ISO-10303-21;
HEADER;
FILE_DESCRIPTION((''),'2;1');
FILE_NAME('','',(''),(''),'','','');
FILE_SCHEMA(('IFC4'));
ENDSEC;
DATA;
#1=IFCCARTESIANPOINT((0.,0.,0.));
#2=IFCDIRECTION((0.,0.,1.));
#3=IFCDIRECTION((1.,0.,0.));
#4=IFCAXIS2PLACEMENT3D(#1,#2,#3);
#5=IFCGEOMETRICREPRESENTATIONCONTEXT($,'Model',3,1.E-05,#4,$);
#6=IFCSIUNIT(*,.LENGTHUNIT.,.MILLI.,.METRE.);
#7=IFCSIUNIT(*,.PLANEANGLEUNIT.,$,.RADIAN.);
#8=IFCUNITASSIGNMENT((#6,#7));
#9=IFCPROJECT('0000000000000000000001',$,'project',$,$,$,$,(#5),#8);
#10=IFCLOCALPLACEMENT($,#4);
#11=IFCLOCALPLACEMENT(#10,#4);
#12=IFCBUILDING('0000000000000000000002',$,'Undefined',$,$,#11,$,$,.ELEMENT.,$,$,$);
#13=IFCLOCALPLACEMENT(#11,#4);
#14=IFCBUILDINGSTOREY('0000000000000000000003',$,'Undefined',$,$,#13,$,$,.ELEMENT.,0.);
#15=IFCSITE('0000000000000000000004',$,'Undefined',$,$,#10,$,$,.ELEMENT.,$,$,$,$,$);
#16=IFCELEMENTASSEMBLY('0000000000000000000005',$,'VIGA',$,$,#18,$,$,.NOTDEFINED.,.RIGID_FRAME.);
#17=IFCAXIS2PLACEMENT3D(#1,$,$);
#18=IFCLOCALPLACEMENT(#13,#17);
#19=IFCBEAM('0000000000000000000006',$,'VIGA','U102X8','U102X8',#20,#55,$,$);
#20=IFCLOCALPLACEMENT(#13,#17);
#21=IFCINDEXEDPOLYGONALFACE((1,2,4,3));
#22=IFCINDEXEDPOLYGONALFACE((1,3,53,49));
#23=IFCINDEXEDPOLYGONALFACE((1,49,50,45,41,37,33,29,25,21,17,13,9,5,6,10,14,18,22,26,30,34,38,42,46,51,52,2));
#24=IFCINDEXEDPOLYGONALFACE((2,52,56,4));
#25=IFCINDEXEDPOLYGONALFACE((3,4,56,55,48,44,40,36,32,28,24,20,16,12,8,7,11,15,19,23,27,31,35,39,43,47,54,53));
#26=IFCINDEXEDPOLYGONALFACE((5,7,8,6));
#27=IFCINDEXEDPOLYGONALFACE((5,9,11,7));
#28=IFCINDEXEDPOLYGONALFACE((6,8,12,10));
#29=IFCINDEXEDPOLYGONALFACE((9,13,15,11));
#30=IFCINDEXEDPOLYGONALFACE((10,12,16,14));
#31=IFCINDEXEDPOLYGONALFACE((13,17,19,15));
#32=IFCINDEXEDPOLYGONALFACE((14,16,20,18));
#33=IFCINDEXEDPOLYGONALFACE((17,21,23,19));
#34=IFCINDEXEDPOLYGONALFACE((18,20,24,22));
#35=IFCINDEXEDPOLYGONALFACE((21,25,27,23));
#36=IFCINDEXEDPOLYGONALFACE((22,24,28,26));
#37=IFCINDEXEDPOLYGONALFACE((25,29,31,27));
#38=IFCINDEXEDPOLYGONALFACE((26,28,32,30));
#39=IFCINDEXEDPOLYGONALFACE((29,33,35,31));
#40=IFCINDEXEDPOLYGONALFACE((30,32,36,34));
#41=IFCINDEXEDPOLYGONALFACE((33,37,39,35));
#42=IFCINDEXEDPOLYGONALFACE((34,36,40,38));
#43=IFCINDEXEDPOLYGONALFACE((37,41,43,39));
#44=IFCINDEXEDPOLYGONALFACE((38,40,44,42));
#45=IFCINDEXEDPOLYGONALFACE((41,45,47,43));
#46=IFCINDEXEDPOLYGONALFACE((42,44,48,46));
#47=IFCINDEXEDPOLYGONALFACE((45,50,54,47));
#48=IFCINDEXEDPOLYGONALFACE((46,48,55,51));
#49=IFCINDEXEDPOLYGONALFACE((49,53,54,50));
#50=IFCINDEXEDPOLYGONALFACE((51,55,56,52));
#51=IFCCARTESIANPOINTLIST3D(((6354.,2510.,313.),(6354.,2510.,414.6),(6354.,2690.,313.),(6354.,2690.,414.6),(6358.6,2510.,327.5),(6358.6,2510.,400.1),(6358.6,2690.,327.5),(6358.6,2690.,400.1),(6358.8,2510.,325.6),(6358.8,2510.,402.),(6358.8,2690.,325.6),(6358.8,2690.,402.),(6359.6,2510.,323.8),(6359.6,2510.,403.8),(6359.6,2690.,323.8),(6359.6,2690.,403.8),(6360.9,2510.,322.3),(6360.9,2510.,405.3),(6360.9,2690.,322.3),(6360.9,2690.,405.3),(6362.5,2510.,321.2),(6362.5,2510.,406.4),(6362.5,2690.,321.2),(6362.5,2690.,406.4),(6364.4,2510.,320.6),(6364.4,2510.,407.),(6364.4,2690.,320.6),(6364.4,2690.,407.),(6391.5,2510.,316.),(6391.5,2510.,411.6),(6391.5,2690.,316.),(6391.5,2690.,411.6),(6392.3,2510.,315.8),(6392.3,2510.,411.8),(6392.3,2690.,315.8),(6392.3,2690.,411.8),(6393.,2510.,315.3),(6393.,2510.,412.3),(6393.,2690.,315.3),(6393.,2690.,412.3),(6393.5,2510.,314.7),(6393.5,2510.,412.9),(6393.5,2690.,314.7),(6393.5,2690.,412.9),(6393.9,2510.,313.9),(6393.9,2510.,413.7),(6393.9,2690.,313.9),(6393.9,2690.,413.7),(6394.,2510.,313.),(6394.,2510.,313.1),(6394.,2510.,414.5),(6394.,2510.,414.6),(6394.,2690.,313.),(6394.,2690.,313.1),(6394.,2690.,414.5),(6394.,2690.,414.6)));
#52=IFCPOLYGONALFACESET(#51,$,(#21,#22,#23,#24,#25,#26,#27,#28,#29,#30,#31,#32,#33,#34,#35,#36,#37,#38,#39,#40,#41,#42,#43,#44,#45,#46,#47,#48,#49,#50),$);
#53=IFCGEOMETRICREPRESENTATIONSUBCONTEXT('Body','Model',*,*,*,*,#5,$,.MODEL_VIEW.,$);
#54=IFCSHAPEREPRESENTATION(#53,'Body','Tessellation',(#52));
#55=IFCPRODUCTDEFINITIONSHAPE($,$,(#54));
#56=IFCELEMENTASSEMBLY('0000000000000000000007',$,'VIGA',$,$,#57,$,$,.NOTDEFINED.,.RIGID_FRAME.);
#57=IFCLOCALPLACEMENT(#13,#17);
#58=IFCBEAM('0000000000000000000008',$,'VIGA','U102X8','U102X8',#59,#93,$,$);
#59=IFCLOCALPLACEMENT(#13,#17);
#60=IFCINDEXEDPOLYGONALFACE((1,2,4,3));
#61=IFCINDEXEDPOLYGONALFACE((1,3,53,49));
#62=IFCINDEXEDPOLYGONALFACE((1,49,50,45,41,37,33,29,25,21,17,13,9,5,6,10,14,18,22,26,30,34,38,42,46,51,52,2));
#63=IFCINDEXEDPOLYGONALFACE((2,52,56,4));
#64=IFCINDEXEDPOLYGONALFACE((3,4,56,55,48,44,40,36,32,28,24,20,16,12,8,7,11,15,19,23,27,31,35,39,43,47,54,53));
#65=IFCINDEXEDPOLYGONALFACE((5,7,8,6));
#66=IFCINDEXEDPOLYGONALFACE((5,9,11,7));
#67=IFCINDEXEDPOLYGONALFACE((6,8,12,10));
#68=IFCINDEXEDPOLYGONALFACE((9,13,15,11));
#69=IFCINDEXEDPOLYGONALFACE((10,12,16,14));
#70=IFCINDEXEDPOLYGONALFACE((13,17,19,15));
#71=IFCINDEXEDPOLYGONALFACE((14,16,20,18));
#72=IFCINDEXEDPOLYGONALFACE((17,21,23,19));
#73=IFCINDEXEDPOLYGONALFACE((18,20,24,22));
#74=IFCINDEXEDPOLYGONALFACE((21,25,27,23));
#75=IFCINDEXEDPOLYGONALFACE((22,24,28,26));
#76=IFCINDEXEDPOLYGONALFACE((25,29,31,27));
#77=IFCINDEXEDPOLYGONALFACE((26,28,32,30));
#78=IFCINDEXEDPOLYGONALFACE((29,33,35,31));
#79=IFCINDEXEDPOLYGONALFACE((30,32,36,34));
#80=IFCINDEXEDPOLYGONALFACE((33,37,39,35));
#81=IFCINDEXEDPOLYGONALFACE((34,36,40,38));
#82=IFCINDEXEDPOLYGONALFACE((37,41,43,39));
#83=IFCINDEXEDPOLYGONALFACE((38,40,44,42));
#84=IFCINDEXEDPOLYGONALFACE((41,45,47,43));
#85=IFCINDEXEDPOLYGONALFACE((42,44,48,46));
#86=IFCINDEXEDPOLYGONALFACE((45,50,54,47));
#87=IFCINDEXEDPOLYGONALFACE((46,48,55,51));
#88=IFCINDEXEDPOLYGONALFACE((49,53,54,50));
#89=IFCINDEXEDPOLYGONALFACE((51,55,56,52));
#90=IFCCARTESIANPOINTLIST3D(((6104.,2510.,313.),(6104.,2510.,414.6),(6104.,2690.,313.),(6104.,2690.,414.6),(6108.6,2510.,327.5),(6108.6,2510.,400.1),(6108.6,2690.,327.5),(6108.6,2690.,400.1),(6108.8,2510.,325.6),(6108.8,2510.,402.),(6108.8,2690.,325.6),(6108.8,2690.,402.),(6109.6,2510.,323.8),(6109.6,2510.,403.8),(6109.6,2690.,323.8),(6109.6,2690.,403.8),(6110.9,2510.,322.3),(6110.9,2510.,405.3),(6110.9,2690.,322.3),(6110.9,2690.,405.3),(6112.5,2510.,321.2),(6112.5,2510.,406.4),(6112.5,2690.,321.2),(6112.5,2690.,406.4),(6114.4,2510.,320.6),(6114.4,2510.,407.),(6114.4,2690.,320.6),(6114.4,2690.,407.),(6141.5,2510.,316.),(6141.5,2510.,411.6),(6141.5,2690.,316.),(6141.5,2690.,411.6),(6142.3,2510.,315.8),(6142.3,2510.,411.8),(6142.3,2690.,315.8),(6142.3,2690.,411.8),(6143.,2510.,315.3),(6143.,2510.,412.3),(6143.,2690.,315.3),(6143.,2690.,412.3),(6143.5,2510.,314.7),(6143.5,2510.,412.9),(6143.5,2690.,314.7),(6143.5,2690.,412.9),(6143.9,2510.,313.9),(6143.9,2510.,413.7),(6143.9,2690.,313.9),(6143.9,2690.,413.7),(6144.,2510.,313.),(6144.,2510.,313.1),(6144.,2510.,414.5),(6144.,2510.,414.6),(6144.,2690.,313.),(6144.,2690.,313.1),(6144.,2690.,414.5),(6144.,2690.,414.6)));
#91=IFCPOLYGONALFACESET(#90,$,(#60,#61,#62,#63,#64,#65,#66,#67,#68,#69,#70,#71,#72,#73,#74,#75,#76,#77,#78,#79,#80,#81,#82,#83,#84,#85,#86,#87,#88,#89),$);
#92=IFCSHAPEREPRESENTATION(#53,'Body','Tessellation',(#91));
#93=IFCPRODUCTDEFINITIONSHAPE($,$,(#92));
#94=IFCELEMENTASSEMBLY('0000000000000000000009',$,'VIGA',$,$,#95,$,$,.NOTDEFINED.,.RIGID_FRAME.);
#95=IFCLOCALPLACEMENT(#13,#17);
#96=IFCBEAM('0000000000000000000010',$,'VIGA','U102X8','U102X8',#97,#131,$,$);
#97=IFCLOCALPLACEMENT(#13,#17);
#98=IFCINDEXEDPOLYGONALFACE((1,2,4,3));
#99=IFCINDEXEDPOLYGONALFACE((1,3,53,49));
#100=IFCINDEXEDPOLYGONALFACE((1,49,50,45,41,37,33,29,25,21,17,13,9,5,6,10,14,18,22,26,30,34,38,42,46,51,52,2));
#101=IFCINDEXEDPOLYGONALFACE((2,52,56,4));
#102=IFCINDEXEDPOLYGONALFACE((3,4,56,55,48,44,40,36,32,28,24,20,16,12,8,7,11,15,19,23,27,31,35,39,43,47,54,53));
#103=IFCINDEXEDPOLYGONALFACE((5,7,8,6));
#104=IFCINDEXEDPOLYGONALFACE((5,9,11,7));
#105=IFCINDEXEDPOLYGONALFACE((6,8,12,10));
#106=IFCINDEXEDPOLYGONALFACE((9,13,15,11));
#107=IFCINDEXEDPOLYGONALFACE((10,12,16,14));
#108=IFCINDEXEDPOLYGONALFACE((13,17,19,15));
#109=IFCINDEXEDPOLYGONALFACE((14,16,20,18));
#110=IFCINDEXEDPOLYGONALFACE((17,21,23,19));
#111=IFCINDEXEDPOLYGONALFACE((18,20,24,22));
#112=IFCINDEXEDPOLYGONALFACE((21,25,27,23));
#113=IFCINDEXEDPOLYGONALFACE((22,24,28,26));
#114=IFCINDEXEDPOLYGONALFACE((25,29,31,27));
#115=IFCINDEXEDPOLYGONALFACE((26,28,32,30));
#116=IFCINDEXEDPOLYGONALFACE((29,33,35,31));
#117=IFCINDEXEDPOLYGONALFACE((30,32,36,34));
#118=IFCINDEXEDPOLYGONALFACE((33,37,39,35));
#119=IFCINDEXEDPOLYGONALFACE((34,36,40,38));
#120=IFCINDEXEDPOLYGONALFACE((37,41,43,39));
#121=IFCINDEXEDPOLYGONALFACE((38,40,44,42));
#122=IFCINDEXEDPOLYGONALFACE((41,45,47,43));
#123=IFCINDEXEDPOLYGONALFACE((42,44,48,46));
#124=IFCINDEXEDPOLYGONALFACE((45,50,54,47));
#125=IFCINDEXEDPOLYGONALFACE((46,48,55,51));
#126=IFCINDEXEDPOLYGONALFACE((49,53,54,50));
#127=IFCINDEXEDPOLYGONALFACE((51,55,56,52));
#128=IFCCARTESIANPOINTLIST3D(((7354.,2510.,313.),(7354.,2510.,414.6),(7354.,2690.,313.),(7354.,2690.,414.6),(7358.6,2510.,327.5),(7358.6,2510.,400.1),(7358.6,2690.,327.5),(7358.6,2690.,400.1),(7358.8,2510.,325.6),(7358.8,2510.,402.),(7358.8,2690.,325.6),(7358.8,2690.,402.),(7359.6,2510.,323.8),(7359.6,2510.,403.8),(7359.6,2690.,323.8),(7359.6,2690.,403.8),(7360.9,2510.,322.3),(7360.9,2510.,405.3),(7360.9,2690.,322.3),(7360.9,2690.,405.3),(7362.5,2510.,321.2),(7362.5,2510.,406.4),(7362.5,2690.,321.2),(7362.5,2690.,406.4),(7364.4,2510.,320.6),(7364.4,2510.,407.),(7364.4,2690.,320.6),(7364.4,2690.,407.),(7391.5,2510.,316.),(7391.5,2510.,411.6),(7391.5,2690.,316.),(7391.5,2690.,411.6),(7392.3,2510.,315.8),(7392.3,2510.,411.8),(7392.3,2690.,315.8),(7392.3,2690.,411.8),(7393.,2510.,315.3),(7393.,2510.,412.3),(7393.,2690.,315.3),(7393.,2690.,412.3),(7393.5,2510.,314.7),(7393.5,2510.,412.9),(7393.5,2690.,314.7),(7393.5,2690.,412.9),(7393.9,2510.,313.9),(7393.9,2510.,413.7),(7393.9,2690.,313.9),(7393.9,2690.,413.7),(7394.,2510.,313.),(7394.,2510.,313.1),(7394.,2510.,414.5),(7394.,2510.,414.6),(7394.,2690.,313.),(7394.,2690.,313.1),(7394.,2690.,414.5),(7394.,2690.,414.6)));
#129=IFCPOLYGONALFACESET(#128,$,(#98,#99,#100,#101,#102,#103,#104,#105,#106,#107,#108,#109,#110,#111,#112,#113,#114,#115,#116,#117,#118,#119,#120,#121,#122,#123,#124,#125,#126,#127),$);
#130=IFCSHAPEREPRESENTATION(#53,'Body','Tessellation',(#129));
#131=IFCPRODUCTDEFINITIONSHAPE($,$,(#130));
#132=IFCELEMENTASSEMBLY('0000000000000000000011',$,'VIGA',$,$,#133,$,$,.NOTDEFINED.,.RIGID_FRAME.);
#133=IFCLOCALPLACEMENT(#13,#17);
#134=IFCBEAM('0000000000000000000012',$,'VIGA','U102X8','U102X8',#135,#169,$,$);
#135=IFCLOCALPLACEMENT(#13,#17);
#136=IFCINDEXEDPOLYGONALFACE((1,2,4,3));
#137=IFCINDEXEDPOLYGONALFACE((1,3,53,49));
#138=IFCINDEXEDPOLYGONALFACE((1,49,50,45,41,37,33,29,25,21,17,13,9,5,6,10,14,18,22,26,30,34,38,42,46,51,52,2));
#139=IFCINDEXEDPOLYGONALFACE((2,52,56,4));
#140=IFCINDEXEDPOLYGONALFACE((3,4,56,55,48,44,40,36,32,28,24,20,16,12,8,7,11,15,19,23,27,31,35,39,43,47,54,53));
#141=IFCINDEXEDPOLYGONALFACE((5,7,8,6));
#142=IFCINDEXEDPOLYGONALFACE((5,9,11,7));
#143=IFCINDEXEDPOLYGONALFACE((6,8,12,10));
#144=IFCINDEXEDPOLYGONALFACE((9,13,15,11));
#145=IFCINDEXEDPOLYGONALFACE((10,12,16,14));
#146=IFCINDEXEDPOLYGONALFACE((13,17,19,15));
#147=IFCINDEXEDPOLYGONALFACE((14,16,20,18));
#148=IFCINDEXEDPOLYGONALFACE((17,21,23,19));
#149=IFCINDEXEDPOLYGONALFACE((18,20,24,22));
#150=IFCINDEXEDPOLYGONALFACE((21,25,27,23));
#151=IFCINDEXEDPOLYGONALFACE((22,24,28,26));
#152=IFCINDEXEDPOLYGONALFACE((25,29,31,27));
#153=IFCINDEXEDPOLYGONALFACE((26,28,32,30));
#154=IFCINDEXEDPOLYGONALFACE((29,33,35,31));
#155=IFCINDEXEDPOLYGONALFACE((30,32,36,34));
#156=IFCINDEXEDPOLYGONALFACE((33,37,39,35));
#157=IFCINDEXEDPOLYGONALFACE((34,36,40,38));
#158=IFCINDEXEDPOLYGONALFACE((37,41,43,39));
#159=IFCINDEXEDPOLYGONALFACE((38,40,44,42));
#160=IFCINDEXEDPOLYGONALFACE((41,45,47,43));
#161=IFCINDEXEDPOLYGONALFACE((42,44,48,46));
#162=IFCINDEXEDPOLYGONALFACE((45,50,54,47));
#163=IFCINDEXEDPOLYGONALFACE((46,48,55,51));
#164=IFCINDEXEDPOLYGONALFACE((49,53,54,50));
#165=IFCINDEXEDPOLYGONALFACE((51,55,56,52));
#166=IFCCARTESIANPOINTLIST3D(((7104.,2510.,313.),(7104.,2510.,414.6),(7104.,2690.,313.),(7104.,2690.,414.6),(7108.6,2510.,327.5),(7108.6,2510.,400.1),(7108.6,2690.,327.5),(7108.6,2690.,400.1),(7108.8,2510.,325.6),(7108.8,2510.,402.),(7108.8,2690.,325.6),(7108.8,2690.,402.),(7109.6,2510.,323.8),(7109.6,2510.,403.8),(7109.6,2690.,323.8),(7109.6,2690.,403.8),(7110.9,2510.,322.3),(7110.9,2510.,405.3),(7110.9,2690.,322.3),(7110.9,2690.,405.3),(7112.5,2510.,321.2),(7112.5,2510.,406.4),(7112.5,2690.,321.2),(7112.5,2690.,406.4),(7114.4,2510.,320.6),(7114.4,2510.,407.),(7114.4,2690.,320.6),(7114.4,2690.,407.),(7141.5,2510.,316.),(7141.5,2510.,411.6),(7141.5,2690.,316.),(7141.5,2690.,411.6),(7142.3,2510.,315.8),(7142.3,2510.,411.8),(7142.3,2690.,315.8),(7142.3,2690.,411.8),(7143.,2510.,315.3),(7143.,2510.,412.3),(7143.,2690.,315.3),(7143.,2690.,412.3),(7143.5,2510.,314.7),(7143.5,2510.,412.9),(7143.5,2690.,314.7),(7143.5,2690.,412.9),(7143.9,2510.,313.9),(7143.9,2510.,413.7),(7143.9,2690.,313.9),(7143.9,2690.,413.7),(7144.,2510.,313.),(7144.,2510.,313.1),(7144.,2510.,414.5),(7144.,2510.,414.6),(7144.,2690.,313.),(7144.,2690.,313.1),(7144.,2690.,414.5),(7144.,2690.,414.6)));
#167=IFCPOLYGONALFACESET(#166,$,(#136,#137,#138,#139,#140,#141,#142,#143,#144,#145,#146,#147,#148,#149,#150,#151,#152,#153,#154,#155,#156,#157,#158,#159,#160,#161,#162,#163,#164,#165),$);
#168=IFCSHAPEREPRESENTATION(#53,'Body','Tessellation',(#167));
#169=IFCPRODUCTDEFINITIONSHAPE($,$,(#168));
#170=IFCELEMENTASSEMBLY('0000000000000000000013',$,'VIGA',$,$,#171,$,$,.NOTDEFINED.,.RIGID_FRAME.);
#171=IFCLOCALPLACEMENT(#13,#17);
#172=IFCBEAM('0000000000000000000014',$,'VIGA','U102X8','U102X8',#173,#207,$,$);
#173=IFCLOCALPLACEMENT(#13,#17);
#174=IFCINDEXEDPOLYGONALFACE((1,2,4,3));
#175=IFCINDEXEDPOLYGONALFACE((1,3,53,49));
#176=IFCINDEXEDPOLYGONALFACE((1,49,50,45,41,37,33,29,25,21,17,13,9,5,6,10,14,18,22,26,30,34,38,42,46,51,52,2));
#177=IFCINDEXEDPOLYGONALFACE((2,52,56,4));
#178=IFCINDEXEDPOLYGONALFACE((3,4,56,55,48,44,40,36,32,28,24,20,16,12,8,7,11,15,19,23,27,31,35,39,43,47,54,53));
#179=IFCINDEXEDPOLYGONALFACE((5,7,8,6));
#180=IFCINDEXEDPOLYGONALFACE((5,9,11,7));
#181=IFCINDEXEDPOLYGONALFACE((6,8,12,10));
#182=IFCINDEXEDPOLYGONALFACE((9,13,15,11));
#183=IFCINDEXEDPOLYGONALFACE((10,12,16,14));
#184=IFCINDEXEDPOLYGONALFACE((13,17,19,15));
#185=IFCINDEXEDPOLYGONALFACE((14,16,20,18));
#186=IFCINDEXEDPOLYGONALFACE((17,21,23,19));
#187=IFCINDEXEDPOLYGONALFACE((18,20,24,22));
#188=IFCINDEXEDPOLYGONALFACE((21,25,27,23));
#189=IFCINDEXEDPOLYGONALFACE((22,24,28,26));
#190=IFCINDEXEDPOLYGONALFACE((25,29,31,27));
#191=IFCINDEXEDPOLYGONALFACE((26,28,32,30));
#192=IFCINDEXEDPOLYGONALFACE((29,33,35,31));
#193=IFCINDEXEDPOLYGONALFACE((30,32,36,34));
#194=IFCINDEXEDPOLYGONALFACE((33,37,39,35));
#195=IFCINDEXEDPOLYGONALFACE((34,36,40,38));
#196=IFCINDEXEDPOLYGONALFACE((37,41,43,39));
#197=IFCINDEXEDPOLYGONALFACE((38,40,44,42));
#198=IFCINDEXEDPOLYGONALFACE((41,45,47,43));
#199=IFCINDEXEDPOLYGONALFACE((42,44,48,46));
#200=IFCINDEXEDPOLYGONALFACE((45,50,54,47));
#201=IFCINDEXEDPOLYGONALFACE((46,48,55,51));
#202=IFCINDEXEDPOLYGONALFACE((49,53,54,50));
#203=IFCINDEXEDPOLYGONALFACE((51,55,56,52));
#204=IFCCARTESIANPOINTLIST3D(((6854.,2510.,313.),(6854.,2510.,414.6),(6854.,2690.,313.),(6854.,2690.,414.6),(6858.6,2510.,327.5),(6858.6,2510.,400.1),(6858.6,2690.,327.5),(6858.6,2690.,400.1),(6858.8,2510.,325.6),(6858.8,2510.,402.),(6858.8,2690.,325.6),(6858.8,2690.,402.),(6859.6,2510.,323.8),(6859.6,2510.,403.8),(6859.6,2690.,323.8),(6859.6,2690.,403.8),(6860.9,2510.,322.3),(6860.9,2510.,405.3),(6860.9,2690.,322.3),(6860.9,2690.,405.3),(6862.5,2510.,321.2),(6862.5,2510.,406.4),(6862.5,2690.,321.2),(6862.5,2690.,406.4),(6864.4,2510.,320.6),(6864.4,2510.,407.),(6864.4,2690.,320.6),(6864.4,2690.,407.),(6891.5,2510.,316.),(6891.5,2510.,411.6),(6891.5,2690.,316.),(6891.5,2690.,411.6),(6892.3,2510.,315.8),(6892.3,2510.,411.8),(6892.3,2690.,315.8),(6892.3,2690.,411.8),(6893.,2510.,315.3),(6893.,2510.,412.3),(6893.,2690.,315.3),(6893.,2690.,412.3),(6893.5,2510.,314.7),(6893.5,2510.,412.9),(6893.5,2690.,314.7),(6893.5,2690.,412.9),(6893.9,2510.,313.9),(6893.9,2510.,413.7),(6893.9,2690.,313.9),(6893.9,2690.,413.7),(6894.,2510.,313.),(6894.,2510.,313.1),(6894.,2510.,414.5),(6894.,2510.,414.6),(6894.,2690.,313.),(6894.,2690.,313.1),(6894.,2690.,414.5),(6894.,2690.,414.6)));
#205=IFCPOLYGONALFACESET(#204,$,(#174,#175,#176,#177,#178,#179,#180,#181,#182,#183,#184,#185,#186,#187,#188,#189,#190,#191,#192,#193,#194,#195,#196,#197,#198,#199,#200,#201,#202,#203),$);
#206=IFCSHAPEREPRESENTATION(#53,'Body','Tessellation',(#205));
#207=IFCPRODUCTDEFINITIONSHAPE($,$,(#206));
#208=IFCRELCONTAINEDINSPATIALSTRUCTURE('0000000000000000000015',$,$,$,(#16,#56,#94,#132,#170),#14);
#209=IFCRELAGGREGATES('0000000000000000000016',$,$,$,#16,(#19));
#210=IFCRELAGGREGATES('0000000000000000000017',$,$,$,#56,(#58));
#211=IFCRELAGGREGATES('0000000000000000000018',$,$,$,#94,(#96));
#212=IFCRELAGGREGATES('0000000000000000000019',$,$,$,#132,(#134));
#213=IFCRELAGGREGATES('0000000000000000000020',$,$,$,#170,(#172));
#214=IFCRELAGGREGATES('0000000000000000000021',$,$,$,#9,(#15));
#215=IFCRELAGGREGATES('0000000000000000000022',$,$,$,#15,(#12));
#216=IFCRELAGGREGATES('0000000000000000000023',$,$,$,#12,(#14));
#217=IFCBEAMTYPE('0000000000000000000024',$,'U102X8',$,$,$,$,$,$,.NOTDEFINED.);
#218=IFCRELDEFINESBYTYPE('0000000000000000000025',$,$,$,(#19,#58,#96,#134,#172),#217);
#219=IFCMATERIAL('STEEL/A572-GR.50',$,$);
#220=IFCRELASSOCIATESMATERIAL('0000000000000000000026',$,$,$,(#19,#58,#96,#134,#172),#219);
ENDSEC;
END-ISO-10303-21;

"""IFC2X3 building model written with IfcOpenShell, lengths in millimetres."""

from ifc_helpers import new_model, si_unit, frame, origin_with_axes, origin_2d_with_axis, place, context, subcontext, project, spatial, u_section, extrude, material, type_object, element, aggregate, save


model = new_model("IFC2X3")

# Units and contexts
model_context = context("Model", 3, precision=1e-05, world=origin_with_axes())
body_context = subcontext(model_context, "Body", "Model", "MODEL_VIEW")
ifc_project = project(units=[si_unit("LENGTHUNIT", "METRE", prefix="MILLI"), si_unit("PLANEANGLEUNIT", "RADIAN")], contexts=[model_context])

# Site, building, storey
site_placement = place(None, origin_with_axes())
site = spatial("IfcSite", under=ifc_project, at=site_placement, Name="Undefined", CompositionType="ELEMENT")
building_placement = place(site_placement, origin_with_axes())
building = spatial("IfcBuilding", under=site, at=building_placement, Name="Undefined", CompositionType="ELEMENT")
storey_placement = place(building_placement, origin_with_axes())
storey = spatial("IfcBuildingStorey", under=building, at=storey_placement, Name="Undefined", CompositionType="ELEMENT", Elevation=0.0)

# Element assemblies, beams
assembly_1_placement = place(storey_placement, origin_with_axes())
assembly_1 = element("IfcElementAssembly", 1, at=assembly_1_placement, inside=storey, Name="VIGA", AssemblyPlace="NOTDEFINED", PredefinedType="RIGID_FRAME")
ifc_material_1 = material(Name="STEEL/A572-GR.50")
beam_type_1 = type_object("IfcBeamType", Name="U102X8", PredefinedType="NOTDEFINED")
beam_1_placement = place(assembly_1_placement, frame((6374.0, 2510.0, 363.8), z_axis=(0.0, 0.0, 1.0), x_axis=(0.0, 1.0, 0.0)))
beam_1 = element("IfcBeam", 2, at=beam_1_placement, type_object=beam_type_1, material=ifc_material_1, Name="VIGA", Description="U102X8", ObjectType="U102X8", context=body_context, shape_type="SweptSolid", body=[
    extrude(u_section(Depth=101.6, FlangeWidth=40.0, WebThickness=4.6, FlangeThickness=6.0, FilletRadius=7.0, EdgeRadius=3.0, FlangeSlope=0.16839, at=origin_2d_with_axis()), frame((180.0, 0.0, 0.0), z_axis=(-1.0, 0.0, 0.0), x_axis=(0.0, -1.0, 0.0)), (0.0, 0.0, 1.0), 180.0),
])
aggregate(assembly_1, [beam_1])
assembly_2_placement = place(storey_placement, origin_with_axes())
assembly_2 = element("IfcElementAssembly", 3, at=assembly_2_placement, inside=storey, Name="VIGA", AssemblyPlace="NOTDEFINED", PredefinedType="RIGID_FRAME")
beam_2_placement = place(assembly_2_placement, frame((6124.0, 2510.0, 363.8), z_axis=(0.0, 0.0, 1.0), x_axis=(0.0, 1.0, 0.0)))
beam_2 = element("IfcBeam", 4, at=beam_2_placement, type_object=beam_type_1, material=ifc_material_1, Name="VIGA", Description="U102X8", ObjectType="U102X8", context=body_context, shape_type="SweptSolid", body=[
    extrude(u_section(Depth=101.6, FlangeWidth=40.0, WebThickness=4.6, FlangeThickness=6.0, FilletRadius=7.0, EdgeRadius=3.0, FlangeSlope=0.16839, at=origin_2d_with_axis()), frame((180.0, 0.0, 0.0), z_axis=(-1.0, 0.0, 0.0), x_axis=(0.0, -1.0, 0.0)), (0.0, 0.0, 1.0), 180.0),
])
aggregate(assembly_2, [beam_2])
assembly_3_placement = place(storey_placement, origin_with_axes())
assembly_3 = element("IfcElementAssembly", 5, at=assembly_3_placement, inside=storey, Name="VIGA", AssemblyPlace="NOTDEFINED", PredefinedType="RIGID_FRAME")
beam_3_placement = place(assembly_3_placement, frame((7374.0, 2510.0, 363.8), z_axis=(0.0, 0.0, 1.0), x_axis=(0.0, 1.0, 0.0)))
beam_3 = element("IfcBeam", 6, at=beam_3_placement, type_object=beam_type_1, material=ifc_material_1, Name="VIGA", Description="U102X8", ObjectType="U102X8", context=body_context, shape_type="SweptSolid", body=[
    extrude(u_section(Depth=101.6, FlangeWidth=40.0, WebThickness=4.6, FlangeThickness=6.0, FilletRadius=7.0, EdgeRadius=3.0, FlangeSlope=0.16839, at=origin_2d_with_axis()), frame((180.0, 0.0, 0.0), z_axis=(-1.0, 0.0, 0.0), x_axis=(0.0, -1.0, 0.0)), (0.0, 0.0, 1.0), 180.0),
])
aggregate(assembly_3, [beam_3])
assembly_4_placement = place(storey_placement, origin_with_axes())
assembly_4 = element("IfcElementAssembly", 7, at=assembly_4_placement, inside=storey, Name="VIGA", AssemblyPlace="NOTDEFINED", PredefinedType="RIGID_FRAME")
beam_4_placement = place(assembly_4_placement, frame((7124.0, 2510.0, 363.8), z_axis=(0.0, 0.0, 1.0), x_axis=(0.0, 1.0, 0.0)))
beam_4 = element("IfcBeam", 8, at=beam_4_placement, type_object=beam_type_1, material=ifc_material_1, Name="VIGA", Description="U102X8", ObjectType="U102X8", context=body_context, shape_type="SweptSolid", body=[
    extrude(u_section(Depth=101.6, FlangeWidth=40.0, WebThickness=4.6, FlangeThickness=6.0, FilletRadius=7.0, EdgeRadius=3.0, FlangeSlope=0.16839, at=origin_2d_with_axis()), frame((180.0, 0.0, 0.0), z_axis=(-1.0, 0.0, 0.0), x_axis=(0.0, -1.0, 0.0)), (0.0, 0.0, 1.0), 180.0),
])
aggregate(assembly_4, [beam_4])
assembly_5_placement = place(storey_placement, origin_with_axes())
assembly_5 = element("IfcElementAssembly", 9, at=assembly_5_placement, inside=storey, Name="VIGA", AssemblyPlace="NOTDEFINED", PredefinedType="RIGID_FRAME")
beam_5_placement = place(assembly_5_placement, frame((6874.0, 2510.0, 363.8), z_axis=(0.0, 0.0, 1.0), x_axis=(0.0, 1.0, 0.0)))
beam_5 = element("IfcBeam", 10, at=beam_5_placement, type_object=beam_type_1, material=ifc_material_1, Name="VIGA", Description="U102X8", ObjectType="U102X8", context=body_context, shape_type="SweptSolid", body=[
    extrude(u_section(Depth=101.6, FlangeWidth=40.0, WebThickness=4.6, FlangeThickness=6.0, FilletRadius=7.0, EdgeRadius=3.0, FlangeSlope=0.16839, at=origin_2d_with_axis()), frame((180.0, 0.0, 0.0), z_axis=(-1.0, 0.0, 0.0), x_axis=(0.0, -1.0, 0.0)), (0.0, 0.0, 1.0), 180.0),
])
aggregate(assembly_5, [beam_5])

save(model, "model.ifc")
